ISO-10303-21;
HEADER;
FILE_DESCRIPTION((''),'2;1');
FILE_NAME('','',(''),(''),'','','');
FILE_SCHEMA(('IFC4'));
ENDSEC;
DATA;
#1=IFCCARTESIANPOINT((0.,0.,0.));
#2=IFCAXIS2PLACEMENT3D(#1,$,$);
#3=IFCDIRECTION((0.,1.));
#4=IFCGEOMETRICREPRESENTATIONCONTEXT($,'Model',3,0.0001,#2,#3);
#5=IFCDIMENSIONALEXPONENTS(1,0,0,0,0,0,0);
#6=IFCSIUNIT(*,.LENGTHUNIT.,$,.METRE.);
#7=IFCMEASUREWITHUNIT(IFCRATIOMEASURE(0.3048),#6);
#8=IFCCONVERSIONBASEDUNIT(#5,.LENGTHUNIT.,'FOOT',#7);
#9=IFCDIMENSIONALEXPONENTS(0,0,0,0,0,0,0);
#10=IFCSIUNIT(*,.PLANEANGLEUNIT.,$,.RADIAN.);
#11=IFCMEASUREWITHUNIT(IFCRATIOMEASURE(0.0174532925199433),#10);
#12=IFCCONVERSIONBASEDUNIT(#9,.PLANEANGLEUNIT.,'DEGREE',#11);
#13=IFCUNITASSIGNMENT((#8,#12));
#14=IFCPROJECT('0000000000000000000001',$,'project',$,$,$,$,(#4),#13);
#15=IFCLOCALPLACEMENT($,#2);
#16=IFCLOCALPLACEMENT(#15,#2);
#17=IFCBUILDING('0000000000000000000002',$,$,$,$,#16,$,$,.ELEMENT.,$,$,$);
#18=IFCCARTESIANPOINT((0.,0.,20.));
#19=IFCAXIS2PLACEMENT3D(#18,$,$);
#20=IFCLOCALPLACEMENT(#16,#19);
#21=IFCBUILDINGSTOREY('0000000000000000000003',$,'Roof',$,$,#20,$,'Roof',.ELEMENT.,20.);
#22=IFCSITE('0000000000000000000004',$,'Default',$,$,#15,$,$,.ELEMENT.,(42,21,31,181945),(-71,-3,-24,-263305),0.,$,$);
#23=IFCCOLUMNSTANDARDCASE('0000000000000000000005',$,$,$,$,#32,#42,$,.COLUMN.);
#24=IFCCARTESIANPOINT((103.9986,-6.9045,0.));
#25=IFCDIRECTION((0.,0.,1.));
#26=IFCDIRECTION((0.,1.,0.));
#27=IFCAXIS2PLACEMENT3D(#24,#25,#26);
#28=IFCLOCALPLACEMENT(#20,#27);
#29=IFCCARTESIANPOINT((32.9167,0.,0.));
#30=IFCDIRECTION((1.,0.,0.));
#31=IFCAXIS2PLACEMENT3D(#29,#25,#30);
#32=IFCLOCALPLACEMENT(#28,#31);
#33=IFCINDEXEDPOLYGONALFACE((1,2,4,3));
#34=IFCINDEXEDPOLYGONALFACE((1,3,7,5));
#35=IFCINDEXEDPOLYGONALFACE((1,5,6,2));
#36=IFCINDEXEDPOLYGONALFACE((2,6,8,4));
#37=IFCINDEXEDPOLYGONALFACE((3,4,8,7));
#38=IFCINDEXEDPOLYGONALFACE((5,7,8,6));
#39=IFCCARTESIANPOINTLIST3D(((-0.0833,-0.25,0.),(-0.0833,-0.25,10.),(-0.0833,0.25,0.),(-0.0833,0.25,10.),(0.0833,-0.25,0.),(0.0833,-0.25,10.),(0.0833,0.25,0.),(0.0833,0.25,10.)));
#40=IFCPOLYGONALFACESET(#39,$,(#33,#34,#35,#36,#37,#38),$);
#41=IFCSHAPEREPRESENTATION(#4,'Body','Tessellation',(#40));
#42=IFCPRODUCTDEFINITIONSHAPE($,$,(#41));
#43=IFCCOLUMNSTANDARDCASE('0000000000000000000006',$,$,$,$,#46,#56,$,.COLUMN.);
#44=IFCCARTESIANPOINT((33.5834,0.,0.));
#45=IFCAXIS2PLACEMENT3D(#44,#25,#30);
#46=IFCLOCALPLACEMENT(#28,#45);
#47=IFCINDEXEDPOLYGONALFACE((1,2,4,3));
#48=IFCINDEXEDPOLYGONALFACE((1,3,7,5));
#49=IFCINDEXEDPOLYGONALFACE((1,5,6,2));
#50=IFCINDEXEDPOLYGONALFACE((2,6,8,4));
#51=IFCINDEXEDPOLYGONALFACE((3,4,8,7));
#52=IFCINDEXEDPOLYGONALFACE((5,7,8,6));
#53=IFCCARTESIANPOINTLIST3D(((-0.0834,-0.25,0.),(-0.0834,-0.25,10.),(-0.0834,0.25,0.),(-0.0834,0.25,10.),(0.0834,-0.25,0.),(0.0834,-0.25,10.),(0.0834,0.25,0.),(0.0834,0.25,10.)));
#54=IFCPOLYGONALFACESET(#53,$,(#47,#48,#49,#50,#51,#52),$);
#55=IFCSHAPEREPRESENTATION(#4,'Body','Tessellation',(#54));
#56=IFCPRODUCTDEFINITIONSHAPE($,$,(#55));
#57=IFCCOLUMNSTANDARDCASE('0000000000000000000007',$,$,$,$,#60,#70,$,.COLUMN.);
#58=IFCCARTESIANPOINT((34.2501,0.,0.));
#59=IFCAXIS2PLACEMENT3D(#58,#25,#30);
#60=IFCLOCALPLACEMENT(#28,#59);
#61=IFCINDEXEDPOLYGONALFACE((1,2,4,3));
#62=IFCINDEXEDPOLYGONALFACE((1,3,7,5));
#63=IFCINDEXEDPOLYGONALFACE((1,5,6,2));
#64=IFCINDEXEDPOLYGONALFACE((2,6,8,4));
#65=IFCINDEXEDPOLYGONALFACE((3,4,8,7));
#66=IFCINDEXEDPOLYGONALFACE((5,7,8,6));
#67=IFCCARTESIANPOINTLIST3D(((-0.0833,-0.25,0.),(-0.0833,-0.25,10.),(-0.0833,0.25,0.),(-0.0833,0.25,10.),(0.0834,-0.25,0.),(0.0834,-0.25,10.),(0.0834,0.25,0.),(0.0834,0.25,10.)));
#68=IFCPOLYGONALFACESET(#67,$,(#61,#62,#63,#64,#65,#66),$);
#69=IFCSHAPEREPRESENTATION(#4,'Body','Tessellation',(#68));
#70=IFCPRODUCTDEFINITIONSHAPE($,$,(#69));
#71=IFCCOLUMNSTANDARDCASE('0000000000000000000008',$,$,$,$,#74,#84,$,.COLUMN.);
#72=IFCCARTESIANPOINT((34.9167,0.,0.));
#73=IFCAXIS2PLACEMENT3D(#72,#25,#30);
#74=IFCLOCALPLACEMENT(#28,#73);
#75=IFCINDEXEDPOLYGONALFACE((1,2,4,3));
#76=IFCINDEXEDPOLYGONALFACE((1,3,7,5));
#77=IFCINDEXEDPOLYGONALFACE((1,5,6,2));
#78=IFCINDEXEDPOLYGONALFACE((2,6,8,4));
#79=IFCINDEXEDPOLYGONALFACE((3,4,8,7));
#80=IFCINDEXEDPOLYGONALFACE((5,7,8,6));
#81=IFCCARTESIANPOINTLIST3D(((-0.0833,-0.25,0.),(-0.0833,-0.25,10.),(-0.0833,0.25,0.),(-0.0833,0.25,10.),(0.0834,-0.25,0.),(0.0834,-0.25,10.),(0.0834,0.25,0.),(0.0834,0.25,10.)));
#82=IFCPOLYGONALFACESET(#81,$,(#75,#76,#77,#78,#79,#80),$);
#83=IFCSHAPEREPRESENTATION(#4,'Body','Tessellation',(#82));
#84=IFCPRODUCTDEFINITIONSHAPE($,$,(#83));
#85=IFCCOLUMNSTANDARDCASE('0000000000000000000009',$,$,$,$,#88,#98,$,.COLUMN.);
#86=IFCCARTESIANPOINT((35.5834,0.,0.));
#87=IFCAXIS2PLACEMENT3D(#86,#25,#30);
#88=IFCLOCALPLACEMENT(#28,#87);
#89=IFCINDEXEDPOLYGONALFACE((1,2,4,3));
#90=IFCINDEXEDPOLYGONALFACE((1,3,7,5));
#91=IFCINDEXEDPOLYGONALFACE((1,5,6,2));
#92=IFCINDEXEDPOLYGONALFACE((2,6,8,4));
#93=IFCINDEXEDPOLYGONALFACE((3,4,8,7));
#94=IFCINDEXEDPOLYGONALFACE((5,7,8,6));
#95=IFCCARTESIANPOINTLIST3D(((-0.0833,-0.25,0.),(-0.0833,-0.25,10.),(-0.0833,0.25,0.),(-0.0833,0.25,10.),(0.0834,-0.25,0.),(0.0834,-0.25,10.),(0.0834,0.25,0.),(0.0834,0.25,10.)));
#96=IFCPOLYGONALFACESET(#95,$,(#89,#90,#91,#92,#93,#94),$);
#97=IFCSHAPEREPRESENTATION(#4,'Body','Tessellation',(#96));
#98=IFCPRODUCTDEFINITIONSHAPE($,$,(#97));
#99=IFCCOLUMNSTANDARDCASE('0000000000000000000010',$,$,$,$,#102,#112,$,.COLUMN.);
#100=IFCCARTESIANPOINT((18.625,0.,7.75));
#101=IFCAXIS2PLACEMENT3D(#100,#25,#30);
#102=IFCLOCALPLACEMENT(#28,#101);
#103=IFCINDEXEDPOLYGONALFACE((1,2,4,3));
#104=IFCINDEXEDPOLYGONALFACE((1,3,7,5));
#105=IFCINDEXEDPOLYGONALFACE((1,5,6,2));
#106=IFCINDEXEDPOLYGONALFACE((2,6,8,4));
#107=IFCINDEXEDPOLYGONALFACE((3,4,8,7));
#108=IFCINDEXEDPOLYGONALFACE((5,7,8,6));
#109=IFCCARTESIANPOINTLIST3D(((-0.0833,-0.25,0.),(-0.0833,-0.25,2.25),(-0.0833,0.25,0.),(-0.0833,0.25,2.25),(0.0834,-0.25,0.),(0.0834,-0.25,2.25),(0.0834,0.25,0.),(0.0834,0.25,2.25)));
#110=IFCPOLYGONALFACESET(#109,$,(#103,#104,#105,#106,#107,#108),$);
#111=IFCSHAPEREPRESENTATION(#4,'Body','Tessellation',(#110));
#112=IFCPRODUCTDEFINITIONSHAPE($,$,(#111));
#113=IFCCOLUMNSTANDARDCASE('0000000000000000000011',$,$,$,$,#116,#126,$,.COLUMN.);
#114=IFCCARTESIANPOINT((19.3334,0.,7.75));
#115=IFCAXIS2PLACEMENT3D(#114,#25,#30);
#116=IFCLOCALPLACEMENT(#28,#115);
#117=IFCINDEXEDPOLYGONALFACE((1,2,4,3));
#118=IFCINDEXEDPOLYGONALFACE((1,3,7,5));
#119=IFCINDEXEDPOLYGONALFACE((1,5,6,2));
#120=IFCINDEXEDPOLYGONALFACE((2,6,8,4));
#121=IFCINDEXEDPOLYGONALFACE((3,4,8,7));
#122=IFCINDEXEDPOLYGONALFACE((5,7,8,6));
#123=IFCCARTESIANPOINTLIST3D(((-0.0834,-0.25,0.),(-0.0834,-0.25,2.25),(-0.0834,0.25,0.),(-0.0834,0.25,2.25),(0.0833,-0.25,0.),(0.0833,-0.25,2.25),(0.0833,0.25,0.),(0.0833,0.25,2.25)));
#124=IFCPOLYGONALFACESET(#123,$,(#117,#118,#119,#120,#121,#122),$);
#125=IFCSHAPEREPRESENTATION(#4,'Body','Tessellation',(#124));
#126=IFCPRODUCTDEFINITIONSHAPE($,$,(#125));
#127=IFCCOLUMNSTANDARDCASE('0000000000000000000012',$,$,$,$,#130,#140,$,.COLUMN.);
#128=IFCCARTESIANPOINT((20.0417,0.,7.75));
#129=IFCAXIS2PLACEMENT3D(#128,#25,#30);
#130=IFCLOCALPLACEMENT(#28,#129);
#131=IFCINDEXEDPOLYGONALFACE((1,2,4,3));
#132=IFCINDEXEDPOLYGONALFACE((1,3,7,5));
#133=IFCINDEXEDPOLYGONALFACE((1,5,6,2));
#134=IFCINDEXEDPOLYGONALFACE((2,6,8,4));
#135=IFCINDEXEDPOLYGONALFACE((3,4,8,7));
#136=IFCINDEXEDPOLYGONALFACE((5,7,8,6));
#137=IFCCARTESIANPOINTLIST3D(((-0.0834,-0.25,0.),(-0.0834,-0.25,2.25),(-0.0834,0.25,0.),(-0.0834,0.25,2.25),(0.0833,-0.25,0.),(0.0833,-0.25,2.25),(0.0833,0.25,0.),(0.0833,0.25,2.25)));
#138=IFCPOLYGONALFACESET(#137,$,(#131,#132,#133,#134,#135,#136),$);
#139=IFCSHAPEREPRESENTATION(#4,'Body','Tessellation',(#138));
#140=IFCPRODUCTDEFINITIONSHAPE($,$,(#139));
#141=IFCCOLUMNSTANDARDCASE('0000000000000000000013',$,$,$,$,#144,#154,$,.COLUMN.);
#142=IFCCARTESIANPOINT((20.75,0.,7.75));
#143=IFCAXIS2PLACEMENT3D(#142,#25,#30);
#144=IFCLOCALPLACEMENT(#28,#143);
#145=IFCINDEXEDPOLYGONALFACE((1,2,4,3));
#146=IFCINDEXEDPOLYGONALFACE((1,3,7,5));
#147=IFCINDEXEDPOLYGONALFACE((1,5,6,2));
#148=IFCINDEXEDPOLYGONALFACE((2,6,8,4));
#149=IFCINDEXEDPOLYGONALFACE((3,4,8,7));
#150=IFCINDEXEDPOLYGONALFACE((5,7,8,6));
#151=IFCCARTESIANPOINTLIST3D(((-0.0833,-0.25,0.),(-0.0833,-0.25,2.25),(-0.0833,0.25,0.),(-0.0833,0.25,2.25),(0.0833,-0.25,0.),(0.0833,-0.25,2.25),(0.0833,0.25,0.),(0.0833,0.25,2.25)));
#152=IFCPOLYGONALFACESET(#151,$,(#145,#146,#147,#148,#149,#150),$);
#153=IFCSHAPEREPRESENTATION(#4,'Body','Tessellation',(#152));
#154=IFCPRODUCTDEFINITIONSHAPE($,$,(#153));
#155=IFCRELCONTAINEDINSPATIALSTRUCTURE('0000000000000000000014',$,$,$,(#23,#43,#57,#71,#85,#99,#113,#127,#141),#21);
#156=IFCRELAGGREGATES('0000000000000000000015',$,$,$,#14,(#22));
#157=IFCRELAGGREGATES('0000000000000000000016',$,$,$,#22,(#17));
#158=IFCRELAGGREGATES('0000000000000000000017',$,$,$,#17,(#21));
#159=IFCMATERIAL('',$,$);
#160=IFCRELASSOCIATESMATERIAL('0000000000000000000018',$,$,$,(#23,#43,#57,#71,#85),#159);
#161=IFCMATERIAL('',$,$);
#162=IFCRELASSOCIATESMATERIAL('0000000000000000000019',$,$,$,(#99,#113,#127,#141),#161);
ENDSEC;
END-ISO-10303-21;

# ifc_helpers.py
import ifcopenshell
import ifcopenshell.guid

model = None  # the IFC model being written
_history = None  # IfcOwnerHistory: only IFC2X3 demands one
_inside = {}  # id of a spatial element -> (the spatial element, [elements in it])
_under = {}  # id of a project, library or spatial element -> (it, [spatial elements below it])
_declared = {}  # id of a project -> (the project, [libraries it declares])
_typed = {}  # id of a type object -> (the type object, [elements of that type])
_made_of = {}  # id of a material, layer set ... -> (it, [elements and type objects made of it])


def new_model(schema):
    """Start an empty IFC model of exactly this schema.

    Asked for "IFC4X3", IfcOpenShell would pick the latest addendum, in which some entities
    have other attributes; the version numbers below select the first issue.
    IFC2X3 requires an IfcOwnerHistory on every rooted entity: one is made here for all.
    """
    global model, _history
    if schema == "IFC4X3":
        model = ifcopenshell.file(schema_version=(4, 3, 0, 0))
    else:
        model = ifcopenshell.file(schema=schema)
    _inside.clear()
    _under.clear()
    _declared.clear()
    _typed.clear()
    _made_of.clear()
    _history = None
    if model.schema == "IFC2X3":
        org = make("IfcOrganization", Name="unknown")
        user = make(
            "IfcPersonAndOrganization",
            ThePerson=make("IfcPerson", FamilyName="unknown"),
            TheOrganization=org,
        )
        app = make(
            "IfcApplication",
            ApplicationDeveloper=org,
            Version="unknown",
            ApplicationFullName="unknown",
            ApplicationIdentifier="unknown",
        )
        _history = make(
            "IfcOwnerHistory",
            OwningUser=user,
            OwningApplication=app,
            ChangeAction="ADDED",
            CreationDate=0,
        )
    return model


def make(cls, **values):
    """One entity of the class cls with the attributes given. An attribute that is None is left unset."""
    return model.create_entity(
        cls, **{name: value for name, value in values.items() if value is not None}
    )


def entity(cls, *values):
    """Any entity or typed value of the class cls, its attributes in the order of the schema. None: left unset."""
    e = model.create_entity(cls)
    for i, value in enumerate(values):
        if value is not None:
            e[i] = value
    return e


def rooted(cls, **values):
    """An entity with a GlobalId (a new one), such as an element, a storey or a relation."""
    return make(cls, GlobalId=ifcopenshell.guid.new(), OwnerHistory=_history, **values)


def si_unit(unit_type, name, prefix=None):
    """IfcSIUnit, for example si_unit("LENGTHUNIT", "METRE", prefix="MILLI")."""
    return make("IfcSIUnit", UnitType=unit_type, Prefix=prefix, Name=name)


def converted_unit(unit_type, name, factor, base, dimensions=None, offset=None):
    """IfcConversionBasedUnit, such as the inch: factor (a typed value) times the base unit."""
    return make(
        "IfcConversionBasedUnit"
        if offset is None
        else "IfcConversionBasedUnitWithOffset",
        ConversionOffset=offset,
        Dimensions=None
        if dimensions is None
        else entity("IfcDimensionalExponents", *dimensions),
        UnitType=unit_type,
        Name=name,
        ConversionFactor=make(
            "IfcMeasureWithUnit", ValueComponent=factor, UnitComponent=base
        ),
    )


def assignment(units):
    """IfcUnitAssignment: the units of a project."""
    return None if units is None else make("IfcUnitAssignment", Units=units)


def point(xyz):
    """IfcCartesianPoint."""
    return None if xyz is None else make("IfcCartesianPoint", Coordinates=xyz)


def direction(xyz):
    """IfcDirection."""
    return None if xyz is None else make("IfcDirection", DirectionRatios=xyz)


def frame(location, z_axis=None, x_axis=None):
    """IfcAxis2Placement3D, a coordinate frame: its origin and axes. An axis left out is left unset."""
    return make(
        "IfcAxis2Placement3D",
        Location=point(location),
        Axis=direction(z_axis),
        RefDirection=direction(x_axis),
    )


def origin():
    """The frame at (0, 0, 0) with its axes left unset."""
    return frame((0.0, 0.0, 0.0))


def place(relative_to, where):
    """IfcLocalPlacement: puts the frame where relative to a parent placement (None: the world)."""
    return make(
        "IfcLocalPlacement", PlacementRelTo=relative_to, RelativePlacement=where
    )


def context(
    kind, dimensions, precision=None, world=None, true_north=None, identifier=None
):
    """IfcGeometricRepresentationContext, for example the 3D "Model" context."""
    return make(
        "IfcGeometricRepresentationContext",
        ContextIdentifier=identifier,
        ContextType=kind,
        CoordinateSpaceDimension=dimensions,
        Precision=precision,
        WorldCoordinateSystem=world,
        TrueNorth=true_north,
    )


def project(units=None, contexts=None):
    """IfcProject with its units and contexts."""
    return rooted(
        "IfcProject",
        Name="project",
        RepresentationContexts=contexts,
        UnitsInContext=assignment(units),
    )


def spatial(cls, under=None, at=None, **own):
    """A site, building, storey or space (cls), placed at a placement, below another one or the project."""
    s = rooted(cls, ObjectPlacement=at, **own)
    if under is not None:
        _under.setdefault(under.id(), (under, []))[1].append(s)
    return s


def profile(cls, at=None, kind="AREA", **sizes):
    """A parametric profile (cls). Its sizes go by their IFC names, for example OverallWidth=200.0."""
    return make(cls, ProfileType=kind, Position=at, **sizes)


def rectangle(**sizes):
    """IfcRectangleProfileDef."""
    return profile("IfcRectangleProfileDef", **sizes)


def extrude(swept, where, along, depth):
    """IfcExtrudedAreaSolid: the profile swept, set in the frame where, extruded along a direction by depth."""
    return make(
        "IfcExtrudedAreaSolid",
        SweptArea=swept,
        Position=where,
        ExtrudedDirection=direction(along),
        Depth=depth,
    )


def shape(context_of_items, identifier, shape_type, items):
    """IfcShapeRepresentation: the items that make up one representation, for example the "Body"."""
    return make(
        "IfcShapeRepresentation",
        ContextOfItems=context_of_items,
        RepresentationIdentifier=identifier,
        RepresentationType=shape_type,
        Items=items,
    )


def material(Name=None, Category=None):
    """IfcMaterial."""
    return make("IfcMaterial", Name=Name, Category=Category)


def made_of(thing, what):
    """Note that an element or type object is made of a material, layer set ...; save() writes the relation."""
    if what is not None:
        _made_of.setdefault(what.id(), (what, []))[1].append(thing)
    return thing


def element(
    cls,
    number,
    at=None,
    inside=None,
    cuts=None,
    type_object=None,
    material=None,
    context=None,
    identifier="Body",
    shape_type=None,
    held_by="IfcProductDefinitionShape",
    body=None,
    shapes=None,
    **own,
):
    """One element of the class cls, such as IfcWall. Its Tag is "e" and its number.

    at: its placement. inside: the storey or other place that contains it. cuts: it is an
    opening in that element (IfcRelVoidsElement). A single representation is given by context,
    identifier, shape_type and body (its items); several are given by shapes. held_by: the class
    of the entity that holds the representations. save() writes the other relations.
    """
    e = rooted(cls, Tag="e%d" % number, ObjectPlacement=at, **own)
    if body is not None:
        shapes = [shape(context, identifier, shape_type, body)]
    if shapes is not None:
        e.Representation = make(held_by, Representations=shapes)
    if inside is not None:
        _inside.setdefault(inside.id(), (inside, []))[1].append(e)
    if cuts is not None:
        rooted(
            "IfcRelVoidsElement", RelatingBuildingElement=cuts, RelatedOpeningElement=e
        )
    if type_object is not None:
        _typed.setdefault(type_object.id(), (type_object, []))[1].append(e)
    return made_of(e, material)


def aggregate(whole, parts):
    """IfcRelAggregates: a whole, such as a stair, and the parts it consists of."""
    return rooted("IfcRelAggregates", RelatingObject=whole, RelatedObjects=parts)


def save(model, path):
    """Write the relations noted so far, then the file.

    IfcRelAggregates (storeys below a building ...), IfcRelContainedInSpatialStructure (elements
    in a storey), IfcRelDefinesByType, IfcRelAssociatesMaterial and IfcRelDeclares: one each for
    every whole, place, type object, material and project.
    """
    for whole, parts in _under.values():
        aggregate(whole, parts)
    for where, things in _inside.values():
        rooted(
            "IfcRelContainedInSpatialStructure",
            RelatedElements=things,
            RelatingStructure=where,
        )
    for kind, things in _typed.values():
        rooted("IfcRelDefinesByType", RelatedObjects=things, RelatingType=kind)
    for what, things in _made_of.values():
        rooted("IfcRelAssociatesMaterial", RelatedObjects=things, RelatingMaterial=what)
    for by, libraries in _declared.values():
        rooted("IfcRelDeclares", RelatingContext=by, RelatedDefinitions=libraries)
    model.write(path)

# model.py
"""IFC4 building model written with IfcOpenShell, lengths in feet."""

from ifc_helpers import new_model, entity, si_unit, converted_unit, direction, frame, origin, place, context, project, spatial, rectangle, extrude, material, element, save


model = new_model("IFC4")

# Units and contexts
model_context = context("Model", 3, precision=0.0001, world=origin(), true_north=direction((0.0, 1.0)))
ifc_project = project(units=[converted_unit("LENGTHUNIT", "FOOT", entity("IfcRatioMeasure", 0.3048), si_unit("LENGTHUNIT", "METRE"), dimensions=[1, 0, 0, 0, 0, 0, 0]), converted_unit("PLANEANGLEUNIT", "DEGREE", entity("IfcRatioMeasure", 0.0174532925199433), si_unit("PLANEANGLEUNIT", "RADIAN"), dimensions=[0, 0, 0, 0, 0, 0, 0])], contexts=[model_context])

# Site, building, storey
site_placement = place(None, origin())
site = spatial("IfcSite", under=ifc_project, at=site_placement, Name="Default", CompositionType="ELEMENT", RefLatitude=(42, 21, 31, 181945), RefLongitude=(-71, -3, -24, -263305), RefElevation=0.0)
building_placement = place(site_placement, origin())
building = spatial("IfcBuilding", under=site, at=building_placement, CompositionType="ELEMENT")
storey_placement = place(building_placement, frame((0.0, 0.0, 20.0)))
storey = spatial("IfcBuildingStorey", under=building, at=storey_placement, Name="Roof", LongName="Roof", CompositionType="ELEMENT", Elevation=20.0)

# Columns
ifc_material_1 = material(Name="")
placement_1 = place(storey_placement, frame((103.9986, -6.9045, 0.0), z_axis=(0.0, 0.0, 1.0), x_axis=(0.0, 1.0, 0.0)))
for number, where, z_axis, x_axis in (
    (1, (32.9167, 0.0, 0.0), (0.0, 0.0, 1.0), (1.0, 0.0, 0.0)),
    (2, (33.5834, 0.0, 0.0), (0.0, 0.0, 1.0), (1.0, 0.0, 0.0)),
    (3, (34.2501, 0.0, 0.0), (0.0, 0.0, 1.0), (1.0, 0.0, 0.0)),
    (4, (34.9167, 0.0, 0.0), (0.0, 0.0, 1.0), (1.0, 0.0, 0.0)),
    (5, (35.5834, 0.0, 0.0), (0.0, 0.0, 1.0), (1.0, 0.0, 0.0)),
):
    element("IfcColumnStandardCase", number, at=place(placement_1, frame(where, z_axis=z_axis, x_axis=x_axis)), inside=storey, material=ifc_material_1, PredefinedType="COLUMN", context=model_context, shape_type="SweptSolid", body=[
        extrude(rectangle(XDim=0.1667, YDim=0.5), origin(), (0.0, 0.0, 1.0), 10.0),
    ])
ifc_material_2 = material(Name="")
for number, where, z_axis, x_axis in (
    (6, (18.625, 0.0, 7.75), (0.0, 0.0, 1.0), (1.0, 0.0, 0.0)),
    (7, (19.3334, 0.0, 7.75), (0.0, 0.0, 1.0), (1.0, 0.0, 0.0)),
    (8, (20.0417, 0.0, 7.75), (0.0, 0.0, 1.0), (1.0, 0.0, 0.0)),
    (9, (20.75, 0.0, 7.75), (0.0, 0.0, 1.0), (1.0, 0.0, 0.0)),
):
    element("IfcColumnStandardCase", number, at=place(placement_1, frame(where, z_axis=z_axis, x_axis=x_axis)), inside=storey, material=ifc_material_2, PredefinedType="COLUMN", context=model_context, shape_type="SweptSolid", body=[
        extrude(rectangle(XDim=0.1667, YDim=0.5), origin(), (0.0, 0.0, 1.0), 2.25),
    ])

save(model, "model.ifc")
